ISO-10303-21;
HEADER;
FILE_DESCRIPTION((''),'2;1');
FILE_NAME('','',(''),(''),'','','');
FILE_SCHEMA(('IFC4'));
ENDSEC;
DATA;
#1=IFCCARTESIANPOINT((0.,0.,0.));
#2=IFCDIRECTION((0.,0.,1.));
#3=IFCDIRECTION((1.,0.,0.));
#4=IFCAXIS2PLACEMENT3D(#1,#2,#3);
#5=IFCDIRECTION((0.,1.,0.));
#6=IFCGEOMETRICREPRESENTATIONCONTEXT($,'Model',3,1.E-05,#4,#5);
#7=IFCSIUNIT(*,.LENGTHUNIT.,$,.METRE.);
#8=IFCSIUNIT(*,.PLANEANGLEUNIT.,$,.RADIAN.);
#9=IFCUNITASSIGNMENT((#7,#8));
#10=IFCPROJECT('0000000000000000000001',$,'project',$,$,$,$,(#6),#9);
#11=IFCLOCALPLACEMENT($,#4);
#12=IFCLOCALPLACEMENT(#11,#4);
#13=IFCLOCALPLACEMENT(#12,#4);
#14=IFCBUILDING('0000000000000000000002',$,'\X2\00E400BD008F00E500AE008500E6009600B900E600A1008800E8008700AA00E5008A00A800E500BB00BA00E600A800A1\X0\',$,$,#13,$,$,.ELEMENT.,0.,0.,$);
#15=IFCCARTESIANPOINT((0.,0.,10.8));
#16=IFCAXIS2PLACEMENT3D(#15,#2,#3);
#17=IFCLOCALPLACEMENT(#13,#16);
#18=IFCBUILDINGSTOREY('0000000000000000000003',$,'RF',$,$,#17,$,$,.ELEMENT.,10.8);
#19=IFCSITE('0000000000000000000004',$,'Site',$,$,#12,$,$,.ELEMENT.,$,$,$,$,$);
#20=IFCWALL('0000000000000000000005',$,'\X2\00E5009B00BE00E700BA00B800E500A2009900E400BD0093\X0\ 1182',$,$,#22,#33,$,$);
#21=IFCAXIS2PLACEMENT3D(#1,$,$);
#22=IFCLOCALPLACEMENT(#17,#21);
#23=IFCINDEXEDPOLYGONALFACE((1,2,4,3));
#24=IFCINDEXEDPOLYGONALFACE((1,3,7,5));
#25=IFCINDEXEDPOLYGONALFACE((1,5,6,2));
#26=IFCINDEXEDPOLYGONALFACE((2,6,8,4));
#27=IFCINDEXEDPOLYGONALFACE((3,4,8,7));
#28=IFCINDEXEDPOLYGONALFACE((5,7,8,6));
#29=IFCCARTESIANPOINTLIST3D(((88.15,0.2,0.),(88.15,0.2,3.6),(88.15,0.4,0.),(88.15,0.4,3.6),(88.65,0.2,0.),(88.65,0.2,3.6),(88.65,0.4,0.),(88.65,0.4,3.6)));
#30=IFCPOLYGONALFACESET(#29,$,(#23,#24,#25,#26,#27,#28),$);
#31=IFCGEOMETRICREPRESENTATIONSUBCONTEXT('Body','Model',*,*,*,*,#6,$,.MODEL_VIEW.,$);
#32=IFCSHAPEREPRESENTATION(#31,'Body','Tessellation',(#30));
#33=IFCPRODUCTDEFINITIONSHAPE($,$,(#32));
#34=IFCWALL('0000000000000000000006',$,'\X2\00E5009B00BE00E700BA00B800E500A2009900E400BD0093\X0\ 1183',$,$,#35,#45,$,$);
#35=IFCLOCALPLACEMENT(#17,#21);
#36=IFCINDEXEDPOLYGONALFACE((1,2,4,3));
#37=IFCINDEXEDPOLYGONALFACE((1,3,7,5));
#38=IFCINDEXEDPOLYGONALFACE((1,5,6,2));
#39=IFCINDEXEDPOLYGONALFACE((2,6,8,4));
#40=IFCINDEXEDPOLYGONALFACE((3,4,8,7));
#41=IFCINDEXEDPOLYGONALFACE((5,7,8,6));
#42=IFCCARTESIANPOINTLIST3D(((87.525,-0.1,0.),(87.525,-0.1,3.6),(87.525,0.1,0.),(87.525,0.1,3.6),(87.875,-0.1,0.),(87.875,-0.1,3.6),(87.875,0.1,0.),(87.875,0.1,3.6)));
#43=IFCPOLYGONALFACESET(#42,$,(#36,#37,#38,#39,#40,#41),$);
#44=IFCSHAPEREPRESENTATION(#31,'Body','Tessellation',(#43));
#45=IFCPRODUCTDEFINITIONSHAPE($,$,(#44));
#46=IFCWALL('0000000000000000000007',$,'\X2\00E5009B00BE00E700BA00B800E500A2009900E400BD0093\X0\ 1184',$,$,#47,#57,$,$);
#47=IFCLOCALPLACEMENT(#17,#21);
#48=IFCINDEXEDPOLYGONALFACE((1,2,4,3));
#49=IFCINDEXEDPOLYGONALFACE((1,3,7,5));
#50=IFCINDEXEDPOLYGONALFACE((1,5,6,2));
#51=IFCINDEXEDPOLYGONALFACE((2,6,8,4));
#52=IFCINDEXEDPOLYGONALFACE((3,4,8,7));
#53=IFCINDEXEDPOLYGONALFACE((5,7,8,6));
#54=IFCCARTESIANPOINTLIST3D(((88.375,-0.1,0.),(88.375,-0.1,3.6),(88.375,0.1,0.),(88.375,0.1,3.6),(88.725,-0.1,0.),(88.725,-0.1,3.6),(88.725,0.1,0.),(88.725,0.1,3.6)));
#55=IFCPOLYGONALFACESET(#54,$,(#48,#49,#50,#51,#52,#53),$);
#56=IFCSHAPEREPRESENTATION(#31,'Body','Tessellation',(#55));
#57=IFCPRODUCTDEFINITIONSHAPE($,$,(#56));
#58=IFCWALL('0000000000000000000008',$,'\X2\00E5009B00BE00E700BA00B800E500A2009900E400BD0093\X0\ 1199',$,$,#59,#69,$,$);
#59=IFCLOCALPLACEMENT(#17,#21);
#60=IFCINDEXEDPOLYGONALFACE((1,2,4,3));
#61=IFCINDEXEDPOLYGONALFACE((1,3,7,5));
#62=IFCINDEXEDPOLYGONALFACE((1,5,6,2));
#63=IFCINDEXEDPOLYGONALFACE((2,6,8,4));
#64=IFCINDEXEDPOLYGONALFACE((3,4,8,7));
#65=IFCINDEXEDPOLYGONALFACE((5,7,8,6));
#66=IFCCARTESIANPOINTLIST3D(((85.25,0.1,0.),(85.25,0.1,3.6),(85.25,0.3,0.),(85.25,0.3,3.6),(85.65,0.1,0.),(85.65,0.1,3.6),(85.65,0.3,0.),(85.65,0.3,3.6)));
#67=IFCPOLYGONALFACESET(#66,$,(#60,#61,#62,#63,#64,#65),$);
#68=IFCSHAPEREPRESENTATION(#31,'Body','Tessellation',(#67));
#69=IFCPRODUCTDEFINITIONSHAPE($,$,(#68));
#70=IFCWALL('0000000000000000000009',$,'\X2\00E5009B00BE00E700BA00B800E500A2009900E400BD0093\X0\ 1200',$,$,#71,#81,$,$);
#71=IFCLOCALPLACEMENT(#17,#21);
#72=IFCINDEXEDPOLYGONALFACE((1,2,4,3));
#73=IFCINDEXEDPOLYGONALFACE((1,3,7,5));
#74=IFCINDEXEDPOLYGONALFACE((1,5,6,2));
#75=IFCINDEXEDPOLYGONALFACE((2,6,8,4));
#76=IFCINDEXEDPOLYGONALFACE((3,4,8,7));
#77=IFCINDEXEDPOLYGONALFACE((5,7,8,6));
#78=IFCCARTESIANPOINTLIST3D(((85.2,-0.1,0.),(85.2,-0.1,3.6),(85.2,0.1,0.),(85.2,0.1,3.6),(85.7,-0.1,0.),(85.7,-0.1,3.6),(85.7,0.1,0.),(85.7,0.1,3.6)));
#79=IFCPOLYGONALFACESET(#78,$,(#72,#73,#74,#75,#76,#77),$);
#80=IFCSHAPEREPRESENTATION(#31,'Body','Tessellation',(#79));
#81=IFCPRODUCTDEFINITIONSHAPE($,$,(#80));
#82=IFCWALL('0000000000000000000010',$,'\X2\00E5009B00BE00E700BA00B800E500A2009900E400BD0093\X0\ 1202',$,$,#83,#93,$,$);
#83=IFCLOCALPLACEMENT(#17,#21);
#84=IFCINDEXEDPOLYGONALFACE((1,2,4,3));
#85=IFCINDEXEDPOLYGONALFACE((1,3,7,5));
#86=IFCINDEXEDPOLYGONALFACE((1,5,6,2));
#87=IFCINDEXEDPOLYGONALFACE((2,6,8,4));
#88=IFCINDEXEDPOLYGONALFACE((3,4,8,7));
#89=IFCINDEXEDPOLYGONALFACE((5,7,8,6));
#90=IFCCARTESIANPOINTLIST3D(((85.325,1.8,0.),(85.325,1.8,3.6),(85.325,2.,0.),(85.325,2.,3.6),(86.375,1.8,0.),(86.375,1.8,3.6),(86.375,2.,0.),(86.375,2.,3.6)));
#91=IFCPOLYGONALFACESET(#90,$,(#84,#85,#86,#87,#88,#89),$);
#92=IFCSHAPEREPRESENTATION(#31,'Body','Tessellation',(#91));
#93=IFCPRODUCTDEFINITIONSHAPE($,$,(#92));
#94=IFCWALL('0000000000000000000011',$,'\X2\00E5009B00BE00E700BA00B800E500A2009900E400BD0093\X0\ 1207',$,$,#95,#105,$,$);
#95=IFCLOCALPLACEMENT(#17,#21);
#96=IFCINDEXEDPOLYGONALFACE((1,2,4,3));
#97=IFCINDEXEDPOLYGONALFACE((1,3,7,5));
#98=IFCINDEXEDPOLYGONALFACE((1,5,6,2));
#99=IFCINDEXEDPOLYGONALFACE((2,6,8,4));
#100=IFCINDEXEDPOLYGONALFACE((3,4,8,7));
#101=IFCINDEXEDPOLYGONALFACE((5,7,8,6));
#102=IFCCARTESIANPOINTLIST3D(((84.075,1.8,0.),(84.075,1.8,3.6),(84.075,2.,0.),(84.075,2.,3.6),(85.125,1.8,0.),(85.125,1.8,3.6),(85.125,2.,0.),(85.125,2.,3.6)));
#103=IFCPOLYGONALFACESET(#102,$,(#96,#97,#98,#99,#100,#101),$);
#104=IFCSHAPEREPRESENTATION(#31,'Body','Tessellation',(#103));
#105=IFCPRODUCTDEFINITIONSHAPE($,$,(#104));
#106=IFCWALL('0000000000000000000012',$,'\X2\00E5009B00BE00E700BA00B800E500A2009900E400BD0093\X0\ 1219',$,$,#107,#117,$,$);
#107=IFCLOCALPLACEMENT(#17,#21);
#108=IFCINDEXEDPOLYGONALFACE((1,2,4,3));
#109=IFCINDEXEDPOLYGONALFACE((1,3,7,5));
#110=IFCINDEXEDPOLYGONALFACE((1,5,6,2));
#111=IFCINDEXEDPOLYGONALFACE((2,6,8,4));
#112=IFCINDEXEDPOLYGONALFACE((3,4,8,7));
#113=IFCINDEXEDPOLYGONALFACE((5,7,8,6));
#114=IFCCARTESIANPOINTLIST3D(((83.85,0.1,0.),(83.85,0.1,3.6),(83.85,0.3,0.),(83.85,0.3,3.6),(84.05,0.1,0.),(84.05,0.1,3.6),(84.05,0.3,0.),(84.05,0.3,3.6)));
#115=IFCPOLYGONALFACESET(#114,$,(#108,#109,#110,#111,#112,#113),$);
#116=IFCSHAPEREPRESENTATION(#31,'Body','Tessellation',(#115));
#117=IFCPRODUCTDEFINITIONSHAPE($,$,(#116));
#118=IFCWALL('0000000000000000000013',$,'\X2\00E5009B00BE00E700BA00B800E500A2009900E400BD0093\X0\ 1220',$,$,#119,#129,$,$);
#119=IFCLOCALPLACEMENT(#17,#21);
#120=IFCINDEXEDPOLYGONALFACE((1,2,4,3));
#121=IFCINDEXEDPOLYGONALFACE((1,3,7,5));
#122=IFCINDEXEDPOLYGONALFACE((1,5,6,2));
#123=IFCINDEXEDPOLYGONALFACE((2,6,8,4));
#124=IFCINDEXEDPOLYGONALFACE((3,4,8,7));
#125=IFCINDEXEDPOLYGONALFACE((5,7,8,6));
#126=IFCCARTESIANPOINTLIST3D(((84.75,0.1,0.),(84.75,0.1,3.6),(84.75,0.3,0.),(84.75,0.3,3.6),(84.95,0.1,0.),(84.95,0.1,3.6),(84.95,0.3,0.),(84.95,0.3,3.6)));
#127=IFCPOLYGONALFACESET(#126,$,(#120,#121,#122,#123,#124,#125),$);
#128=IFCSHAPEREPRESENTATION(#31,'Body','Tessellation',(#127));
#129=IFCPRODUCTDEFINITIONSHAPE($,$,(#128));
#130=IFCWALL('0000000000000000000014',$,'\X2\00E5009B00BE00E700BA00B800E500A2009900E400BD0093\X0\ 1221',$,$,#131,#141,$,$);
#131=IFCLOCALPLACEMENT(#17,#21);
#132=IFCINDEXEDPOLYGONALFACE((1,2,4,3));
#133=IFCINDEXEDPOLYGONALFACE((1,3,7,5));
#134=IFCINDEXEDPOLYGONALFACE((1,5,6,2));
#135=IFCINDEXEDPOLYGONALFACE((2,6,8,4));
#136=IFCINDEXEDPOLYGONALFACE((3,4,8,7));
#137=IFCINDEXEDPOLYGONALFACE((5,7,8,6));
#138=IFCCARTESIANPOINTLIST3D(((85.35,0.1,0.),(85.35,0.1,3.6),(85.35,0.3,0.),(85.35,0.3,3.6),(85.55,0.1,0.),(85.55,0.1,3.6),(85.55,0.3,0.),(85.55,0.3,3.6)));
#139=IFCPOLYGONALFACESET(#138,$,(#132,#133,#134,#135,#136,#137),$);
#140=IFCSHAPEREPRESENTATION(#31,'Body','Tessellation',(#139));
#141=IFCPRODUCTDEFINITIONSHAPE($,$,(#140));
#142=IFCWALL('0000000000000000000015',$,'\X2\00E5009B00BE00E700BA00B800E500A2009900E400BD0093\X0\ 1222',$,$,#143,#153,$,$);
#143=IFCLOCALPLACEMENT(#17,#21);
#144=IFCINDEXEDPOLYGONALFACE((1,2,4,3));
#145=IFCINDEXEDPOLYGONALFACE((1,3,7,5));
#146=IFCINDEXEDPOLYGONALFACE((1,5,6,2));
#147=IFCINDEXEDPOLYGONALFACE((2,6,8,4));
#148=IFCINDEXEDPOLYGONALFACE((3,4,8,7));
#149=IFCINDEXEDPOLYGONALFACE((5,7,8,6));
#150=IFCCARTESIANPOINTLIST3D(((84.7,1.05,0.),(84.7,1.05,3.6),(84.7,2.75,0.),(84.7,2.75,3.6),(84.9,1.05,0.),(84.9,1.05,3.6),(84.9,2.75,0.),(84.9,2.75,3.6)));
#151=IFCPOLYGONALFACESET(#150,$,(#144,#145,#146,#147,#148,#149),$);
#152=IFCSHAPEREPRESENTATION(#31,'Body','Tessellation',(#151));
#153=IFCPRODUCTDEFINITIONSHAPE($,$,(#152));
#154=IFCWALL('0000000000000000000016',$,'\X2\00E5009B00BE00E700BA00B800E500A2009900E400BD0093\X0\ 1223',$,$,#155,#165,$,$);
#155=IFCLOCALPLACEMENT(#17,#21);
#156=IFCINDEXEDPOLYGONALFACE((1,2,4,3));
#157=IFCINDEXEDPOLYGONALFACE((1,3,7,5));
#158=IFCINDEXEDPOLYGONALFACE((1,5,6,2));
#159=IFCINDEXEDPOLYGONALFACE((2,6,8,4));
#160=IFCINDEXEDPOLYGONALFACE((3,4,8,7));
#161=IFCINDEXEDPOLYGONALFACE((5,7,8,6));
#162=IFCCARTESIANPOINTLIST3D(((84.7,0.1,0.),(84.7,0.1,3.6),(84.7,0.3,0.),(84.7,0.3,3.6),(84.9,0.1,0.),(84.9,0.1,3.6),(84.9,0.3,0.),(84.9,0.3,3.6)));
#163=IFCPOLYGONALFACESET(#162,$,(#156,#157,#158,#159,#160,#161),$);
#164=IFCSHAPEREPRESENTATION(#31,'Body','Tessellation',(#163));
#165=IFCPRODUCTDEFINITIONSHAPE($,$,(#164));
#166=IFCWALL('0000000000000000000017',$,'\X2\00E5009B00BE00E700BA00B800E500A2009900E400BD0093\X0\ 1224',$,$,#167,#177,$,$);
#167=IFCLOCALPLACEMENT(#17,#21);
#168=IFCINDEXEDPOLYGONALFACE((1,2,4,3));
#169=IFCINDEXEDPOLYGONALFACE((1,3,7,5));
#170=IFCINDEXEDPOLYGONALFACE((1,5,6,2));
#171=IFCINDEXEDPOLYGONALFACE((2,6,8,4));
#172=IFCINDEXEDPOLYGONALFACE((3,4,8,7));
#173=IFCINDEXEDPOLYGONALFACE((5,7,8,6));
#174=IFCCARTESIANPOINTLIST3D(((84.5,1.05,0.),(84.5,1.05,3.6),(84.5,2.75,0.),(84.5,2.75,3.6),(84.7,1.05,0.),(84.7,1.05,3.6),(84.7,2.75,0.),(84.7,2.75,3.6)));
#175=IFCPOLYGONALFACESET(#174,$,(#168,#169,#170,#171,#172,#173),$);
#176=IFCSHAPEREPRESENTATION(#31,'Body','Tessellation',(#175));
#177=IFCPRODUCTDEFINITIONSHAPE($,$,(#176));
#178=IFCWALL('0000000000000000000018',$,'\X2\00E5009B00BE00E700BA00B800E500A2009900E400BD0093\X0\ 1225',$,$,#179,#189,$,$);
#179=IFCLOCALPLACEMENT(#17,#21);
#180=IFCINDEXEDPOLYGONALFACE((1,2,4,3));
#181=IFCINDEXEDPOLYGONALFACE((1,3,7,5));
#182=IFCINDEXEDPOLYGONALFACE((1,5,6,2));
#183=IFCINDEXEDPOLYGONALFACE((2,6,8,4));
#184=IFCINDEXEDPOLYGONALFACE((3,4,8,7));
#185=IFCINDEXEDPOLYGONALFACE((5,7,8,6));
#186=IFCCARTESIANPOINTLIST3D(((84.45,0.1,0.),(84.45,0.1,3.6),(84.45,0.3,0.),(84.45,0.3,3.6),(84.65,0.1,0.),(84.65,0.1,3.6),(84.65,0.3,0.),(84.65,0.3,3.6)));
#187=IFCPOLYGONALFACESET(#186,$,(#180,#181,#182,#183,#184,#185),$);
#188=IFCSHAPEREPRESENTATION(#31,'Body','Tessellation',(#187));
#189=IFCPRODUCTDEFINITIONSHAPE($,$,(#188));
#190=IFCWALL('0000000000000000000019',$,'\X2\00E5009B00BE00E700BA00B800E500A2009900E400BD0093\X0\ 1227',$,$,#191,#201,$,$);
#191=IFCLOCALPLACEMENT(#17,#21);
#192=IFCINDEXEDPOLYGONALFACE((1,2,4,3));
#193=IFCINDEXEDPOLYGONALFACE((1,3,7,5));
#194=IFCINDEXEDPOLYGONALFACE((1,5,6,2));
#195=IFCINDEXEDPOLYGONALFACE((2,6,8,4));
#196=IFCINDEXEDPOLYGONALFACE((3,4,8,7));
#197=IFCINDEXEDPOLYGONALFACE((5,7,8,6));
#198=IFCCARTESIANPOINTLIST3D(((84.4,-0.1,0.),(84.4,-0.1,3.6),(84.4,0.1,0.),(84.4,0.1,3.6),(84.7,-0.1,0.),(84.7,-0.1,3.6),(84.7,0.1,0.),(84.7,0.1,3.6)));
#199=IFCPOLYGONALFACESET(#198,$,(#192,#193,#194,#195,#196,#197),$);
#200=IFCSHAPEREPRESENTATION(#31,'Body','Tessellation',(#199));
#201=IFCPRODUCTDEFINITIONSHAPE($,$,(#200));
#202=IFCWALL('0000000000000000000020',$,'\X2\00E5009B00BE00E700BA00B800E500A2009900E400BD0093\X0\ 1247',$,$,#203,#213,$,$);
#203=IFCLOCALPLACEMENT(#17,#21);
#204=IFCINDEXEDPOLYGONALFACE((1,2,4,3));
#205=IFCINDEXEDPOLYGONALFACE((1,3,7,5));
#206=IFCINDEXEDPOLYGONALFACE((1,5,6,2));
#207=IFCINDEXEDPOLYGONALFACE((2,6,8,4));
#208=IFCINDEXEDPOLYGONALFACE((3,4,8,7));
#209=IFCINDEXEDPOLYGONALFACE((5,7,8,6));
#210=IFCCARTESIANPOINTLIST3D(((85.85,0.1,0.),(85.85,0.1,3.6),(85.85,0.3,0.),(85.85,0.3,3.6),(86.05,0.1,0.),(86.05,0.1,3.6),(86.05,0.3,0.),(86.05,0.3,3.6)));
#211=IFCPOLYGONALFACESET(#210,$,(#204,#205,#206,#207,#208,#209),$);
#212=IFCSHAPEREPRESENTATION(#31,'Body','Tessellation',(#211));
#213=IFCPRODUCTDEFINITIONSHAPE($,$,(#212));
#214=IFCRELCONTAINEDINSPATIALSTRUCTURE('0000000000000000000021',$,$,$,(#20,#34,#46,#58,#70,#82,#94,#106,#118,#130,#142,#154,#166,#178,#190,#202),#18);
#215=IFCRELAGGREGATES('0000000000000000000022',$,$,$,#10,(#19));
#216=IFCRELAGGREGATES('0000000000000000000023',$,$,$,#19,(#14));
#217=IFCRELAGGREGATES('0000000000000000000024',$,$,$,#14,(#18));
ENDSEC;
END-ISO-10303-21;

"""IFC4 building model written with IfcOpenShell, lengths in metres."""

from ifc_helpers import new_model, si_unit, direction, frame, frame_2d, origin_with_axes, place, context, subcontext, project, spatial, rectangle, extrude, element, save


model = new_model("IFC4")

# Units and contexts
model_context = context("Model", 3, precision=1e-05, world=origin_with_axes(), true_north=direction((0.0, 1.0, 0.0)))
body_context = subcontext(model_context, "Body", "Model", "MODEL_VIEW")
ifc_project = project(units=[si_unit("LENGTHUNIT", "METRE"), si_unit("PLANEANGLEUNIT", "RADIAN")], contexts=[model_context])

# Site, building, storey
placement = place(None, origin_with_axes())
site_placement = place(placement, origin_with_axes())
site = spatial("IfcSite", under=ifc_project, at=site_placement, Name="Site", CompositionType="ELEMENT")
building_placement = place(site_placement, origin_with_axes())
building = spatial("IfcBuilding", under=site, at=building_placement, Name="ä½\u008få®\u0085æ\u0096¹æ¡\u0088è\u0087ªå\u008a¨å»ºæ¨¡", CompositionType="ELEMENT", ElevationOfRefHeight=0.0, ElevationOfTerrain=0.0)
storey_placement = place(building_placement, frame((0.0, 0.0, 10.8), z_axis=(0.0, 0.0, 1.0), x_axis=(1.0, 0.0, 0.0)))
storey = spatial("IfcBuildingStorey", under=building, at=storey_placement, Name="RF", CompositionType="ELEMENT", Elevation=10.8)

# Walls
wall_1_placement = place(storey_placement, frame((88.4, 0.3, 0.0), z_axis=(0.0, 0.0, 1.0), x_axis=(1.0, 0.0, 0.0)))
element("IfcWall", 1, at=wall_1_placement, inside=storey, Name="å\u009b¾çº¸å¢\u0099ä½\u0093 1182", context=body_context, shape_type="SweptSolid", body=[
    extrude(rectangle(XDim=0.5, YDim=0.2, at=frame_2d((0.0, 0.0), x_axis=(1.0, 0.0, 0.0))), frame((0.0, 0.0, 0.0), z_axis=(0.0, 0.0, 1.0)), (0.0, 0.0, 1.0), 3.6),
])
for number, where, z_axis, x_axis, name in (
    (2, (87.7, 0.0, 0.0), (0.0, 0.0, 1.0), (1.0, 0.0, 0.0), "å\u009b¾çº¸å¢\u0099ä½\u0093 1183"),
    (3, (88.55, 0.0, 0.0), (0.0, 0.0, 1.0), (1.0, 0.0, 0.0), "å\u009b¾çº¸å¢\u0099ä½\u0093 1184"),
):
    element("IfcWall", number, at=place(storey_placement, frame(where, z_axis=z_axis, x_axis=x_axis)), inside=storey, Name=name, context=body_context, shape_type="SweptSolid", body=[
        extrude(rectangle(XDim=0.35, YDim=0.2, at=frame_2d((0.0, 0.0), x_axis=(1.0, 0.0, 0.0))), frame((0.0, 0.0, 0.0), z_axis=(0.0, 0.0, 1.0)), (0.0, 0.0, 1.0), 3.6),
    ])
wall_2_placement = place(storey_placement, frame((85.45, 0.2, 0.0), z_axis=(0.0, 0.0, 1.0), x_axis=(1.0, 0.0, 0.0)))
element("IfcWall", 4, at=wall_2_placement, inside=storey, Name="å\u009b¾çº¸å¢\u0099ä½\u0093 1199", context=body_context, shape_type="SweptSolid", body=[
    extrude(rectangle(XDim=0.4, YDim=0.2, at=frame_2d((0.0, 0.0), x_axis=(1.0, 0.0, 0.0))), frame((0.0, 0.0, 0.0), z_axis=(0.0, 0.0, 1.0)), (0.0, 0.0, 1.0), 3.6),
])
wall_3_placement = place(storey_placement, frame((85.45, 0.0, 0.0), z_axis=(0.0, 0.0, 1.0), x_axis=(1.0, 0.0, 0.0)))
element("IfcWall", 5, at=wall_3_placement, inside=storey, Name="å\u009b¾çº¸å¢\u0099ä½\u0093 1200", context=body_context, shape_type="SweptSolid", body=[
    extrude(rectangle(XDim=0.5, YDim=0.2, at=frame_2d((0.0, 0.0), x_axis=(1.0, 0.0, 0.0))), frame((0.0, 0.0, 0.0), z_axis=(0.0, 0.0, 1.0)), (0.0, 0.0, 1.0), 3.6),
])
for number, where, z_axis, x_axis, name in (
    (6, (85.85, 1.9, 0.0), (0.0, 0.0, 1.0), (-1.0, 0.0, 0.0), "å\u009b¾çº¸å¢\u0099ä½\u0093 1202"),
    (7, (84.6, 1.9, 0.0), (0.0, 0.0, 1.0), (-1.0, 0.0, 0.0), "å\u009b¾çº¸å¢\u0099ä½\u0093 1207"),
):
    element("IfcWall", number, at=place(storey_placement, frame(where, z_axis=z_axis, x_axis=x_axis)), inside=storey, Name=name, context=body_context, shape_type="SweptSolid", body=[
        extrude(rectangle(XDim=1.05, YDim=0.2, at=frame_2d((0.0, 0.0), x_axis=(1.0, 0.0, 0.0))), frame((0.0, 0.0, 0.0), z_axis=(0.0, 0.0, 1.0)), (0.0, 0.0, 1.0), 3.6),
    ])
for number, where, z_axis, x_axis, name in (
    (8, (83.95, 0.2, 0.0), (0.0, 0.0, 1.0), (0.0, -1.0, 0.0), "å\u009b¾çº¸å¢\u0099ä½\u0093 1219"),
    (9, (84.85, 0.2, 0.0), (0.0, 0.0, 1.0), (0.0, -1.0, 0.0), "å\u009b¾çº¸å¢\u0099ä½\u0093 1220"),
    (10, (85.45, 0.2, 0.0), (0.0, 0.0, 1.0), (0.0, -1.0, 0.0), "å\u009b¾çº¸å¢\u0099ä½\u0093 1221"),
):
    element("IfcWall", number, at=place(storey_placement, frame(where, z_axis=z_axis, x_axis=x_axis)), inside=storey, Name=name, context=body_context, shape_type="SweptSolid", body=[
        extrude(rectangle(XDim=0.2, YDim=0.2, at=frame_2d((0.0, 0.0), x_axis=(1.0, 0.0, 0.0))), frame((0.0, 0.0, 0.0), z_axis=(0.0, 0.0, 1.0)), (0.0, 0.0, 1.0), 3.6),
    ])
wall_4_placement = place(storey_placement, frame((84.8, 1.9, 0.0), z_axis=(0.0, 0.0, 1.0), x_axis=(0.0, -1.0, 0.0)))
element("IfcWall", 11, at=wall_4_placement, inside=storey, Name="å\u009b¾çº¸å¢\u0099ä½\u0093 1222", context=body_context, shape_type="SweptSolid", body=[
    extrude(rectangle(XDim=1.7, YDim=0.2, at=frame_2d((0.0, 0.0), x_axis=(1.0, 0.0, 0.0))), frame((0.0, 0.0, 0.0), z_axis=(0.0, 0.0, 1.0)), (0.0, 0.0, 1.0), 3.6),
])
wall_5_placement = place(storey_placement, frame((84.8, 0.2, 0.0), z_axis=(0.0, 0.0, 1.0), x_axis=(1.0, 0.0, 0.0)))
element("IfcWall", 12, at=wall_5_placement, inside=storey, Name="å\u009b¾çº¸å¢\u0099ä½\u0093 1223", context=body_context, shape_type="SweptSolid", body=[
    extrude(rectangle(XDim=0.2, YDim=0.2, at=frame_2d((0.0, 0.0), x_axis=(1.0, 0.0, 0.0))), frame((0.0, 0.0, 0.0), z_axis=(0.0, 0.0, 1.0)), (0.0, 0.0, 1.0), 3.6),
])
wall_6_placement = place(storey_placement, frame((84.6, 1.9, 0.0), z_axis=(0.0, 0.0, 1.0), x_axis=(0.0, -1.0, 0.0)))
element("IfcWall", 13, at=wall_6_placement, inside=storey, Name="å\u009b¾çº¸å¢\u0099ä½\u0093 1224", context=body_context, shape_type="SweptSolid", body=[
    extrude(rectangle(XDim=1.7, YDim=0.2, at=frame_2d((0.0, 0.0), x_axis=(1.0, 0.0, 0.0))), frame((0.0, 0.0, 0.0), z_axis=(0.0, 0.0, 1.0)), (0.0, 0.0, 1.0), 3.6),
])
for number, where, z_axis, x_axis, name in (
    (14, (84.55, 0.2, 0.0), (0.0, 0.0, 1.0), (1.0, 0.0, 0.0), "å\u009b¾çº¸å¢\u0099ä½\u0093 1225"),
):
    element("IfcWall", number, at=place(storey_placement, frame(where, z_axis=z_axis, x_axis=x_axis)), inside=storey, Name=name, context=body_context, shape_type="SweptSolid", body=[
        extrude(rectangle(XDim=0.2, YDim=0.2, at=frame_2d((0.0, 0.0), x_axis=(1.0, 0.0, 0.0))), frame((0.0, 0.0, 0.0), z_axis=(0.0, 0.0, 1.0)), (0.0, 0.0, 1.0), 3.6),
    ])
wall_7_placement = place(storey_placement, frame((84.55, 0.0, 0.0), z_axis=(0.0, 0.0, 1.0), x_axis=(1.0, 0.0, 0.0)))
element("IfcWall", 15, at=wall_7_placement, inside=storey, Name="å\u009b¾çº¸å¢\u0099ä½\u0093 1227", context=body_context, shape_type="SweptSolid", body=[
    extrude(rectangle(XDim=0.3, YDim=0.2, at=frame_2d((0.0, 0.0), x_axis=(1.0, 0.0, 0.0))), frame((0.0, 0.0, 0.0), z_axis=(0.0, 0.0, 1.0)), (0.0, 0.0, 1.0), 3.6),
])
for number, where, z_axis, x_axis, name in (
    (16, (85.95, 0.2, 0.0), (0.0, 0.0, 1.0), (0.0, -1.0, 0.0), "å\u009b¾çº¸å¢\u0099ä½\u0093 1247"),
):
    element("IfcWall", number, at=place(storey_placement, frame(where, z_axis=z_axis, x_axis=x_axis)), inside=storey, Name=name, context=body_context, shape_type="SweptSolid", body=[
        extrude(rectangle(XDim=0.2, YDim=0.2, at=frame_2d((0.0, 0.0), x_axis=(1.0, 0.0, 0.0))), frame((0.0, 0.0, 0.0), z_axis=(0.0, 0.0, 1.0)), (0.0, 0.0, 1.0), 3.6),
    ])

save(model, "model.ifc")
